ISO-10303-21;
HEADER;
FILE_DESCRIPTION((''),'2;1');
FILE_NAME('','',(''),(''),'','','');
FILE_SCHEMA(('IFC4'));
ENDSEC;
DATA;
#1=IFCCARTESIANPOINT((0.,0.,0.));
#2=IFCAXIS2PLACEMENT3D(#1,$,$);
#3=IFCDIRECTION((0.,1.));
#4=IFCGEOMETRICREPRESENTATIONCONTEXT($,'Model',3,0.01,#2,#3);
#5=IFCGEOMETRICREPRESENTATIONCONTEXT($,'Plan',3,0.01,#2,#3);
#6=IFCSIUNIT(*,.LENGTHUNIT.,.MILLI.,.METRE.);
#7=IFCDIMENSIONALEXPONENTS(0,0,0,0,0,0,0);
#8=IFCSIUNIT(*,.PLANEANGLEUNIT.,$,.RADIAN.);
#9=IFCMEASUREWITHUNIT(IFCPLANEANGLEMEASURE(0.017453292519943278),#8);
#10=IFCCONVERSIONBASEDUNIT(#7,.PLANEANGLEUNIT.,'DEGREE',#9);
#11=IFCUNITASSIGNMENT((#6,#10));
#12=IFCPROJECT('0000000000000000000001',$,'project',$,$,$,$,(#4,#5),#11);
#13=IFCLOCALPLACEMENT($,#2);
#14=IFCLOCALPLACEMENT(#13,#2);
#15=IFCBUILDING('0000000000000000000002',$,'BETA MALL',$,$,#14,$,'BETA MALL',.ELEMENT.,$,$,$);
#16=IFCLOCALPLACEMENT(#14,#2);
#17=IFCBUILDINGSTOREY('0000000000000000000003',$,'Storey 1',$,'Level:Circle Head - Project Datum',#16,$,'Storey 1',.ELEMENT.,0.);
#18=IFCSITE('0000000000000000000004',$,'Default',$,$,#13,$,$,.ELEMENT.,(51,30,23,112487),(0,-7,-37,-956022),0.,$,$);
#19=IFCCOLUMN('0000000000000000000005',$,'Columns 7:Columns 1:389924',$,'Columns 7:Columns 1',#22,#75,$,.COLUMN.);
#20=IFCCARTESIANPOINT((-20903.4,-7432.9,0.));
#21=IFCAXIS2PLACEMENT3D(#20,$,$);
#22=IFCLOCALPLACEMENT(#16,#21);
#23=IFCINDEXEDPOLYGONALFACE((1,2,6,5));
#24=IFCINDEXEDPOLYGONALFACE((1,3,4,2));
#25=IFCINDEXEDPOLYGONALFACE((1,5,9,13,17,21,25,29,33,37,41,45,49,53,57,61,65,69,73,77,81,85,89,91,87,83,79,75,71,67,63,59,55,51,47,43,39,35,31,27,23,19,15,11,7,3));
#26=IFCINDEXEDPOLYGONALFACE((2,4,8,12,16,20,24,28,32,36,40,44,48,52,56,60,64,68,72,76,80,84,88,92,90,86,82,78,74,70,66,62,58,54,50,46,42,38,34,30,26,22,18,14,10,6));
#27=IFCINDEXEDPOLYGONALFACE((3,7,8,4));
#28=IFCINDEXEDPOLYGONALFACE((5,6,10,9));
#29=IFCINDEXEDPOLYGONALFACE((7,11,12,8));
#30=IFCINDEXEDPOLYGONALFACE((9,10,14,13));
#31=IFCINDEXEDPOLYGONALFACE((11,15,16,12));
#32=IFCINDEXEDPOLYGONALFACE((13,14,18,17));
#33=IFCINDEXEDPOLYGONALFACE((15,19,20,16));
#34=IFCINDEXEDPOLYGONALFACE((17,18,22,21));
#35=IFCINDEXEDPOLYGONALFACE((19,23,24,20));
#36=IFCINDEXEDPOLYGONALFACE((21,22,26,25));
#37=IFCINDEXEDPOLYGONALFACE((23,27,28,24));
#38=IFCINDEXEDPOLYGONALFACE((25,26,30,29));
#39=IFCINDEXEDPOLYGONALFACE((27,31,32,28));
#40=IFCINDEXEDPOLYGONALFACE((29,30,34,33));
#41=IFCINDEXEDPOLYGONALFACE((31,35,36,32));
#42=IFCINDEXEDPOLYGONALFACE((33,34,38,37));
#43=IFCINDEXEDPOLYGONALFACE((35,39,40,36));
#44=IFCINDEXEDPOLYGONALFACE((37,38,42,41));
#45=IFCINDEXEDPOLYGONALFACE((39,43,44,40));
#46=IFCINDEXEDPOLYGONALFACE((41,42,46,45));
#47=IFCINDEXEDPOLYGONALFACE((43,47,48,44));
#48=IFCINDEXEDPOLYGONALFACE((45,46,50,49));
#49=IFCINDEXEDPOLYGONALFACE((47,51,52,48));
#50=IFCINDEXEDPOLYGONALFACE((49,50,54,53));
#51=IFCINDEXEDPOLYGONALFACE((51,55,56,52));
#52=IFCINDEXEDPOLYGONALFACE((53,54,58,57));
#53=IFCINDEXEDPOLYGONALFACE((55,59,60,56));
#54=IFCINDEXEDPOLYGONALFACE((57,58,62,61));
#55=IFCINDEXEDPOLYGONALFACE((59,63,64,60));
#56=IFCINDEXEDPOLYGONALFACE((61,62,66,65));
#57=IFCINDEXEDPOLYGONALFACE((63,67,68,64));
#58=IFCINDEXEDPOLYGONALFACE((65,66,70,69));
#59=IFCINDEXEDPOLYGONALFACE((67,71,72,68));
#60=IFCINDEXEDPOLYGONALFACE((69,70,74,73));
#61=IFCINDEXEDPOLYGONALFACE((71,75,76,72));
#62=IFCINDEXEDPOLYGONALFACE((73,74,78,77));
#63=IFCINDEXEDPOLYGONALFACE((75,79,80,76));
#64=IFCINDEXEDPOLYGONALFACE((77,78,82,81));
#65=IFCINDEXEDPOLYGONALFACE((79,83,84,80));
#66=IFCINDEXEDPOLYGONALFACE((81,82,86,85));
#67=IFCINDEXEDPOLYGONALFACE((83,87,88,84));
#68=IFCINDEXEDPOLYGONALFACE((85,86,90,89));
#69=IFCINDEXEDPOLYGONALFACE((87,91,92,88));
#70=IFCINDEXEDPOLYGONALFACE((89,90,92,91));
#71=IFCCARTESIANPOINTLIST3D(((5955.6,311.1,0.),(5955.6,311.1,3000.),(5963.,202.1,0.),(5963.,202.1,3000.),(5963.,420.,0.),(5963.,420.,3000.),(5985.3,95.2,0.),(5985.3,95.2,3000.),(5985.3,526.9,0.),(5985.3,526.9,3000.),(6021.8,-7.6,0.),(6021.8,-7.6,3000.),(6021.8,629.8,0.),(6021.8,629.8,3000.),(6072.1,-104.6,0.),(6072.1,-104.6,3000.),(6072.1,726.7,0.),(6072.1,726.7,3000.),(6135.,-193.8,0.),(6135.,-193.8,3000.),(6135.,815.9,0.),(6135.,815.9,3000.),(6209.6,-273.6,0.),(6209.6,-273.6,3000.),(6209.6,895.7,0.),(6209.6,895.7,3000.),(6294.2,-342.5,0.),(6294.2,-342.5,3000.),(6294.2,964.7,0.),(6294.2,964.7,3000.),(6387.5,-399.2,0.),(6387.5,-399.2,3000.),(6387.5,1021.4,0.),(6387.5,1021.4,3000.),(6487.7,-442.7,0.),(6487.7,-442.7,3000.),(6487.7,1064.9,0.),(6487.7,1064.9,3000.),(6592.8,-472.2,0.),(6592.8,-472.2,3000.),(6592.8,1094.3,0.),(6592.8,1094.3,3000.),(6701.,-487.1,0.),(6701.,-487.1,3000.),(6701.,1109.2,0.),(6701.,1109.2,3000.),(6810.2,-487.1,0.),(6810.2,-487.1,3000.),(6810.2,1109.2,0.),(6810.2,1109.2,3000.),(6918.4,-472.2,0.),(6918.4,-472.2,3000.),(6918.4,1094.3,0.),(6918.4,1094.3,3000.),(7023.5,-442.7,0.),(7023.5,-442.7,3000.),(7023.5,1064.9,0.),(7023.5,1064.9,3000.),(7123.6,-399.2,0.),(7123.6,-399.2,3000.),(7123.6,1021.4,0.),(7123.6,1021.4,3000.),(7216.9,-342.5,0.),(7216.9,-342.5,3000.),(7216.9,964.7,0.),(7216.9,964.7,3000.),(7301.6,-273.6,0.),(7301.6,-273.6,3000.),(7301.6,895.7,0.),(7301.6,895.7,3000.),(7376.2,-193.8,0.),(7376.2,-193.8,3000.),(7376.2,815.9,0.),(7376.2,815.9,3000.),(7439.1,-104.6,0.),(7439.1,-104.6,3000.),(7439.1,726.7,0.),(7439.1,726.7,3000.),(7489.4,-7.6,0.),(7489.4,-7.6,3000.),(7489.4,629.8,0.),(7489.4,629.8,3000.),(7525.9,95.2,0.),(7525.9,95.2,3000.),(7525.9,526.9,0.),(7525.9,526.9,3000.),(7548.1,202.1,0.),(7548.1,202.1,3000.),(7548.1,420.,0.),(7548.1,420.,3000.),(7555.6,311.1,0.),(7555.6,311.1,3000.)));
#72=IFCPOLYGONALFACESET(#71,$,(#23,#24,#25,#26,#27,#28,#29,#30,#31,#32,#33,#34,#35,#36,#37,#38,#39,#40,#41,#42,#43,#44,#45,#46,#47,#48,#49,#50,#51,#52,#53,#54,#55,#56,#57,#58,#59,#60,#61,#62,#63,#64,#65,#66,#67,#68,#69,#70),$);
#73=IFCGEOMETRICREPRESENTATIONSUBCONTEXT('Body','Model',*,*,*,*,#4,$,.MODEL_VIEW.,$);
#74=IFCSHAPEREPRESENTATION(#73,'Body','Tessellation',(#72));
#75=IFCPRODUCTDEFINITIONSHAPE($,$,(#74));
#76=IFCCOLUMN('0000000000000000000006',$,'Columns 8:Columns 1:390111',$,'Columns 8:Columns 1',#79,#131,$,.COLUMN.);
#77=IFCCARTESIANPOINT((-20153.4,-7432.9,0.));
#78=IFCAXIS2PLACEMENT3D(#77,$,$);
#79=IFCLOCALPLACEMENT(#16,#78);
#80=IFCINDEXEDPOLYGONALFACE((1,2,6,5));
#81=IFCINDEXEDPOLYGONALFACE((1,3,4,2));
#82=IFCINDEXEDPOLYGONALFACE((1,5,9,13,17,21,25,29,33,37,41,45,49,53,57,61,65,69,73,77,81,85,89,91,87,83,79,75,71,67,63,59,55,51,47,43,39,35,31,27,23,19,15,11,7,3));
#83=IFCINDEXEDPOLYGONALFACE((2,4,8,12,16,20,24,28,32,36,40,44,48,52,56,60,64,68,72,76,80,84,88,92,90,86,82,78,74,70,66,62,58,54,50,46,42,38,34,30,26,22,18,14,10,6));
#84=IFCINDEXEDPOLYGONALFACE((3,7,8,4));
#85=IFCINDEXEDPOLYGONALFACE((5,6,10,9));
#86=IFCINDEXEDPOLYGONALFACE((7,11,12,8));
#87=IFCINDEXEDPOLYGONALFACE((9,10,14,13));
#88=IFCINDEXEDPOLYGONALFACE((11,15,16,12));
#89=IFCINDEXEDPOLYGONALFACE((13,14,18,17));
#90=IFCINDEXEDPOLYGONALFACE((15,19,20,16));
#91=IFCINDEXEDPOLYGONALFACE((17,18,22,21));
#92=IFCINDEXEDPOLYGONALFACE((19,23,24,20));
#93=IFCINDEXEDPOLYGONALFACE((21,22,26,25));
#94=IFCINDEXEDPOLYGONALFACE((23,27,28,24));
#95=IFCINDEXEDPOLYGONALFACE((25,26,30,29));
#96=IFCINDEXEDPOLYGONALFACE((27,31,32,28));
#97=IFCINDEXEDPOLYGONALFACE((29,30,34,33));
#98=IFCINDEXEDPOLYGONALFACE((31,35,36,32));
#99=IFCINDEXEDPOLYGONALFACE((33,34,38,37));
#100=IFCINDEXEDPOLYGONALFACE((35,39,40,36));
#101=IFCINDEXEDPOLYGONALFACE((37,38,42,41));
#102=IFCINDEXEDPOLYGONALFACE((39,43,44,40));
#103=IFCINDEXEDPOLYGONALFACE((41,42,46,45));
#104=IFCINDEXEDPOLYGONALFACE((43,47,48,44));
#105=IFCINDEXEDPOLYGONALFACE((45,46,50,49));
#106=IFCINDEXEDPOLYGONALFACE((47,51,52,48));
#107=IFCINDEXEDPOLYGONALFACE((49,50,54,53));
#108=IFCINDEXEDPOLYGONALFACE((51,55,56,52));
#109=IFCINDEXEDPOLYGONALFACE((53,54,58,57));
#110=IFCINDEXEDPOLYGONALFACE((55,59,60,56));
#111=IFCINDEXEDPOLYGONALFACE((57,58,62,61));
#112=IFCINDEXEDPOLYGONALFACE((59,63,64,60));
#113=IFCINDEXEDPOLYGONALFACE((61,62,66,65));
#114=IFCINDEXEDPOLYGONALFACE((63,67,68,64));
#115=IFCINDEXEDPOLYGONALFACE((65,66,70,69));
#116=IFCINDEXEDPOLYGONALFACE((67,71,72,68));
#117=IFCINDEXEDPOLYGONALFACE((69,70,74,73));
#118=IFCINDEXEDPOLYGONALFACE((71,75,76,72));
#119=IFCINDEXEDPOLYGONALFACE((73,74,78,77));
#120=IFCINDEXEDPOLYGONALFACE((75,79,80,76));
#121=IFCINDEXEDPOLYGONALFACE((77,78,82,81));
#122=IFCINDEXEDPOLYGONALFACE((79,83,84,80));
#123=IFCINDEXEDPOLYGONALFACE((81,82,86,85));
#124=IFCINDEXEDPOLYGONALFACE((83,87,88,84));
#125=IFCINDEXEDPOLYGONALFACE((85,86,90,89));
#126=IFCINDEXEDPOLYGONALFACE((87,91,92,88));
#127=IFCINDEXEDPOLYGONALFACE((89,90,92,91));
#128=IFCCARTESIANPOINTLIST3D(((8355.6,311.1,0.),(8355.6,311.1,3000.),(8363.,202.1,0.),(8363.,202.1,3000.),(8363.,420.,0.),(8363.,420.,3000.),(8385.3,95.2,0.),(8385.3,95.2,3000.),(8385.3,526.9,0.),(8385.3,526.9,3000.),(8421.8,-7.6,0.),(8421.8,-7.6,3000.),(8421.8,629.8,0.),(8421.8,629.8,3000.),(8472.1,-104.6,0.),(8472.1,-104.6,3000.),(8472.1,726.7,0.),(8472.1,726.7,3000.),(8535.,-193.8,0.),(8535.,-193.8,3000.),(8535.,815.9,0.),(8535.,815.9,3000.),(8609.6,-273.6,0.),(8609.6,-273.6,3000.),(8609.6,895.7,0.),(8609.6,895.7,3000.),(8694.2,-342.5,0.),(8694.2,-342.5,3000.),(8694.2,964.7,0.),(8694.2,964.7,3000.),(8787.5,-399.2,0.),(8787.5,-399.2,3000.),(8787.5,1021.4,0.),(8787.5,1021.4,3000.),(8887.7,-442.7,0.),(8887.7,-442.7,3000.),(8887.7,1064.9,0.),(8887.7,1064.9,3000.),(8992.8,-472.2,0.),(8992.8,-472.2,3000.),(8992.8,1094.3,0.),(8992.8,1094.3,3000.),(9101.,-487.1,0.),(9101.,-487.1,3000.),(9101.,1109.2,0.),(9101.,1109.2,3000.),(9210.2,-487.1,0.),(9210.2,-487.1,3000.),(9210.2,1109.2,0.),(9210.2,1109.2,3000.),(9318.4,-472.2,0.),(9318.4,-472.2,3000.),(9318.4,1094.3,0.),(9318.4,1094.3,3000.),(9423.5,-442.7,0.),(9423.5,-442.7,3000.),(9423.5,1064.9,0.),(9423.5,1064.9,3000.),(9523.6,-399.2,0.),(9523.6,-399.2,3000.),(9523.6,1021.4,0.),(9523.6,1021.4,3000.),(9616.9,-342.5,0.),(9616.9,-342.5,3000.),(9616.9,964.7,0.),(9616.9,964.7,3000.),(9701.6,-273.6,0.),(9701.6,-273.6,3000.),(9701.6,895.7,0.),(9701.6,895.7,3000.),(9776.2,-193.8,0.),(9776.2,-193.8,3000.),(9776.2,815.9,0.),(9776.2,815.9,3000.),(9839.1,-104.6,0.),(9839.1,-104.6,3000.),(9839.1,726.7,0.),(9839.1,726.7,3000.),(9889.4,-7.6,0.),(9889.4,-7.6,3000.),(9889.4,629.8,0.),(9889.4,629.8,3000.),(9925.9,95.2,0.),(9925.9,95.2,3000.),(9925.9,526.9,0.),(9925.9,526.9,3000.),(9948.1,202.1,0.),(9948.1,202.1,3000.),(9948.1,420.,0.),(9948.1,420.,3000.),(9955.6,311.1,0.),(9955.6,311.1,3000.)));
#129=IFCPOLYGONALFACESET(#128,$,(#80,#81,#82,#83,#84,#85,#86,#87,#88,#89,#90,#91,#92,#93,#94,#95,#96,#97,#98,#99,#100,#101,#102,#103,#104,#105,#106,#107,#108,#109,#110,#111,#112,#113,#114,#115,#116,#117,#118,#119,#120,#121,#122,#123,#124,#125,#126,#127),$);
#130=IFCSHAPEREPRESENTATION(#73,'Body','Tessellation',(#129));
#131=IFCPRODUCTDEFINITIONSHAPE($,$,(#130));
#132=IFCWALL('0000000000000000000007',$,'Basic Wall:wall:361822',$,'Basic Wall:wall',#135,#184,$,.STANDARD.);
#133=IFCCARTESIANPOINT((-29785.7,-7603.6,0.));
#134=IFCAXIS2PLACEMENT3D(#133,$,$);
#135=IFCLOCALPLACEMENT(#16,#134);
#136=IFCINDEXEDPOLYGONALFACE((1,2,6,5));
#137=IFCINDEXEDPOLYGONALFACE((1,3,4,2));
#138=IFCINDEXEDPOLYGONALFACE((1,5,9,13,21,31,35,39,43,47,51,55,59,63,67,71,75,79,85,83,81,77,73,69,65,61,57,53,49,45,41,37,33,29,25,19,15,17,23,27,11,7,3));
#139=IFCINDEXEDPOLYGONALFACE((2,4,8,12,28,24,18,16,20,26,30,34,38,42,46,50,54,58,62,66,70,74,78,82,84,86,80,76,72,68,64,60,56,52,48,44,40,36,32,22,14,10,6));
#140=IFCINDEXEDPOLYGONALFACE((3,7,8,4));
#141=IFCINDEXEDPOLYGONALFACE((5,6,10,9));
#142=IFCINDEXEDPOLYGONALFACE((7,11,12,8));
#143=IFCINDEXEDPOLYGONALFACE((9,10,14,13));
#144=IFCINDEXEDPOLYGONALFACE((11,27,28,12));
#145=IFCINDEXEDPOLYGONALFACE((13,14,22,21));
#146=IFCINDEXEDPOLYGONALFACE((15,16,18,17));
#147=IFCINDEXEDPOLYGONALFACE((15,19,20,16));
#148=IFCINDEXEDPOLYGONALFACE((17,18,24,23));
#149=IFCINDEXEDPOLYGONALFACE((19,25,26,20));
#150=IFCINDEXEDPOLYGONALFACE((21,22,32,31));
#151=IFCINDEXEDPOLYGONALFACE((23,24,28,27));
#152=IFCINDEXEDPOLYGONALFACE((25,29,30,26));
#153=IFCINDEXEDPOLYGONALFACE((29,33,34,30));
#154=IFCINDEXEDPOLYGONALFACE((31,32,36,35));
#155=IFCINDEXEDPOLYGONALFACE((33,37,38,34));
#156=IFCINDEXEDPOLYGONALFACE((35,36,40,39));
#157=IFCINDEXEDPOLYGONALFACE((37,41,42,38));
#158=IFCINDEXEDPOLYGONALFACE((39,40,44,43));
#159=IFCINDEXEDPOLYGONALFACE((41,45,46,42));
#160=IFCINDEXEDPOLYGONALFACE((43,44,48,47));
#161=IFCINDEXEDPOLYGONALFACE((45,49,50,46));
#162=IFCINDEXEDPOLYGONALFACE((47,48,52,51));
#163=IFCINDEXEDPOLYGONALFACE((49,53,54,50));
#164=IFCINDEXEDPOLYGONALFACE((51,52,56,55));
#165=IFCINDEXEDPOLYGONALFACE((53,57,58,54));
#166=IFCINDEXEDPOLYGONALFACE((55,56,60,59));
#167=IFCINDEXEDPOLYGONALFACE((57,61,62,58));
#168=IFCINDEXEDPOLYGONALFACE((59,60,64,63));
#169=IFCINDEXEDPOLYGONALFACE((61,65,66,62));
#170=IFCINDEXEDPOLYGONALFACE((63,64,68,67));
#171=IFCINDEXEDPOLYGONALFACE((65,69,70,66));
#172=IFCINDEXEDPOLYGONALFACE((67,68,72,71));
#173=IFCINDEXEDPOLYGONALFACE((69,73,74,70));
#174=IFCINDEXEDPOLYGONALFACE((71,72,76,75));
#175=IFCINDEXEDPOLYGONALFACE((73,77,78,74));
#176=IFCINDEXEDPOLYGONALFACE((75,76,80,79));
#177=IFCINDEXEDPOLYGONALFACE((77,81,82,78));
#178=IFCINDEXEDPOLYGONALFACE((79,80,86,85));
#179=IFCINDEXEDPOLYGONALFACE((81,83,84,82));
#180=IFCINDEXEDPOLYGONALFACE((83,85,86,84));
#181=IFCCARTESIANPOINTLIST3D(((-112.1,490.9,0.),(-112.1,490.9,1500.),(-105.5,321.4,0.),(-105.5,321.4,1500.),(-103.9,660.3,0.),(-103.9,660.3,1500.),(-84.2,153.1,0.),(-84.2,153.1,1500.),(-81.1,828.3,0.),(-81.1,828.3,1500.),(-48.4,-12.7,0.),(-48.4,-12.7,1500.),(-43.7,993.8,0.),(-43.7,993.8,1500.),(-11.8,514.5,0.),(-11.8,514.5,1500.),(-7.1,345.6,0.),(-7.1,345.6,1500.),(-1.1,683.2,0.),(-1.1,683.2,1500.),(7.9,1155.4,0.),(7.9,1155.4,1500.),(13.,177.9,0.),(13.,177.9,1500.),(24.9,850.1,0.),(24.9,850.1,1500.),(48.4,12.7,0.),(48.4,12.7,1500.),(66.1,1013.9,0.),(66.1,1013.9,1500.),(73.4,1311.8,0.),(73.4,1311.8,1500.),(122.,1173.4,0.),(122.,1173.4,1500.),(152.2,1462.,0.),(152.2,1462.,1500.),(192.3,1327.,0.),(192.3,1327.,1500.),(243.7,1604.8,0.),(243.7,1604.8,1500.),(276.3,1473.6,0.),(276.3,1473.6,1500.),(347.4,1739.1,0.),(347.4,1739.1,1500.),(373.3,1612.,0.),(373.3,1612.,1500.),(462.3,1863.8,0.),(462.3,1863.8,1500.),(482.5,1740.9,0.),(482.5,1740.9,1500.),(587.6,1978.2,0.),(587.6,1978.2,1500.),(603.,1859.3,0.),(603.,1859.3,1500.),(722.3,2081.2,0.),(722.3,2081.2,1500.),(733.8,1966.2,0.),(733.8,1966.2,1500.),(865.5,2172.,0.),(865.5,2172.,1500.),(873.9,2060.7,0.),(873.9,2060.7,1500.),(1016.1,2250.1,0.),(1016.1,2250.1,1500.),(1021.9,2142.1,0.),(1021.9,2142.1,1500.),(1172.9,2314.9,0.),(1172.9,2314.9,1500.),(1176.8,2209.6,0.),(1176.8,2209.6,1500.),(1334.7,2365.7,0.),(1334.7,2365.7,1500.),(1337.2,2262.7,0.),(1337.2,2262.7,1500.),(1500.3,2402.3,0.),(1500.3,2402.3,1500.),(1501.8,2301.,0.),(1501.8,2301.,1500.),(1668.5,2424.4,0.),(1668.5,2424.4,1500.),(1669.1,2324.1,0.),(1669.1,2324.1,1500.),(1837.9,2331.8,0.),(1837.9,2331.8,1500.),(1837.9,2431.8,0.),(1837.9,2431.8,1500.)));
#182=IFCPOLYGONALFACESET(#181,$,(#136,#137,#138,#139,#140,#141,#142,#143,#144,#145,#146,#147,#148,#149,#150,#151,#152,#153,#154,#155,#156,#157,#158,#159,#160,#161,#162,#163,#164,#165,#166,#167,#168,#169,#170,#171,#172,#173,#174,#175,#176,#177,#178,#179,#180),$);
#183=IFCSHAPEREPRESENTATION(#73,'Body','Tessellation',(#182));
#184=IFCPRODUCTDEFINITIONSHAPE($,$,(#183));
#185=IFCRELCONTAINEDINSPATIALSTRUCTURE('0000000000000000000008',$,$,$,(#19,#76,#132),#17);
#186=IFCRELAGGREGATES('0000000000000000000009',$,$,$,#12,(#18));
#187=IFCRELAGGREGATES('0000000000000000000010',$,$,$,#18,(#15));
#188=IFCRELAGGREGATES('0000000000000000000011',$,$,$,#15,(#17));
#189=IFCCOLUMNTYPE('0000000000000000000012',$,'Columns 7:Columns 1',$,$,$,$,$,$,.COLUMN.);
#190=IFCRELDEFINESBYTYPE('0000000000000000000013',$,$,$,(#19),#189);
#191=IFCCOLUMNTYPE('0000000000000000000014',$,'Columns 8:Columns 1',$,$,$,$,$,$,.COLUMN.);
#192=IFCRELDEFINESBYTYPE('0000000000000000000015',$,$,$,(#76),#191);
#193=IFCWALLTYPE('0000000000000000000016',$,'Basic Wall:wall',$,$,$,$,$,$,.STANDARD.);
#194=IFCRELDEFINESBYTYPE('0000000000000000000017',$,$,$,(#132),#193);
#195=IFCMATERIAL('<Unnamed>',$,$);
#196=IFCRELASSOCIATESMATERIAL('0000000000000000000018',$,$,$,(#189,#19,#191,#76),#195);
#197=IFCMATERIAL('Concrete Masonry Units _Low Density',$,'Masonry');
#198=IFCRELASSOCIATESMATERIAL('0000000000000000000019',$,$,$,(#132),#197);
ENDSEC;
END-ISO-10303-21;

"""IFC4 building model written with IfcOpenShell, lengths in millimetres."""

from ifc_helpers import new_model, entity, si_unit, converted_unit, direction, frame, origin, place, context, subcontext, project, spatial, line, arc, indexed_curve, outline, extrude, source, transform, mapped, material, type_object, type_shapes, element, save


model = new_model("IFC4")

# Units and contexts
model_context = context("Model", 3, precision=0.01, world=origin(), true_north=direction((0.0, 1.0)))
plan_context = context("Plan", 3, precision=0.01, world=origin(), true_north=direction((0.0, 1.0)))
body_context = subcontext(model_context, "Body", "Model", "MODEL_VIEW")
ifc_project = project(units=[si_unit("LENGTHUNIT", "METRE", prefix="MILLI"), converted_unit("PLANEANGLEUNIT", "DEGREE", entity("IfcPlaneAngleMeasure", 0.017453292519943278), si_unit("PLANEANGLEUNIT", "RADIAN"), dimensions=[0, 0, 0, 0, 0, 0, 0])], contexts=[model_context, plan_context])

# Site, building, storey
site_placement = place(None, origin())
site = spatial("IfcSite", under=ifc_project, at=site_placement, Name="Default", CompositionType="ELEMENT", RefLatitude=(51, 30, 23, 112487), RefLongitude=(0, -7, -37, -956022), RefElevation=0.0)
building_placement = place(site_placement, origin())
building = spatial("IfcBuilding", under=site, at=building_placement, Name="BETA MALL", LongName="BETA MALL", CompositionType="ELEMENT")
storey_placement = place(building_placement, origin())
storey = spatial("IfcBuildingStorey", under=building, at=storey_placement, Name="Storey 1", ObjectType="Level:Circle Head - Project Datum", LongName="Storey 1", CompositionType="ELEMENT", Elevation=0.0)

# Columns
ifc_material_1 = material(Name="<Unnamed>")
column_type_1 = type_object("IfcColumnType", Name="Columns 7:Columns 1", PredefinedType="COLUMN", material=ifc_material_1)
shared_shape_1 = source(origin(), body_context, "Body", "SweptSolid", [
    extrude(outline(indexed_curve([(-800.0, 0.0), (0.0, -800.0), (800.0, 0.0), (0.0, 800.0)], segments=[arc(1, 2, 3), arc(3, 4, 1)], self_intersect=False)), frame((6755.6, 311.1, 0.0)), (0.0, 0.0, 1.0), 3000.0),
])
type_shapes(column_type_1, [shared_shape_1])
column_1_placement = place(storey_placement, frame((-20903.4, -7432.9, 0.0)))
element("IfcColumn", 1, at=column_1_placement, inside=storey, type_object=column_type_1, material=ifc_material_1, Name="Columns 7:Columns 1:389924", ObjectType="Columns 7:Columns 1", PredefinedType="COLUMN", context=body_context, shape_type="MappedRepresentation", body=[
    mapped(shared_shape_1, transform((0.0, 0.0, 0.0), scale=1.0)),
])
column_type_2 = type_object("IfcColumnType", Name="Columns 8:Columns 1", PredefinedType="COLUMN", material=ifc_material_1)
shared_shape_2 = source(origin(), body_context, "Body", "SweptSolid", [
    extrude(outline(indexed_curve([(-800.0, 0.0), (0.0, -800.0), (800.0, 0.0), (0.0, 800.0)], segments=[arc(1, 2, 3), arc(3, 4, 1)], self_intersect=False)), frame((9155.6, 311.1, 0.0)), (0.0, 0.0, 1.0), 3000.0),
])
type_shapes(column_type_2, [shared_shape_2])
column_2_placement = place(storey_placement, frame((-20153.4, -7432.9, 0.0)))
element("IfcColumn", 2, at=column_2_placement, inside=storey, type_object=column_type_2, material=ifc_material_1, Name="Columns 8:Columns 1:390111", ObjectType="Columns 8:Columns 1", PredefinedType="COLUMN", context=body_context, shape_type="MappedRepresentation", body=[
    mapped(shared_shape_2, transform((0.0, 0.0, 0.0), scale=1.0)),
])

# Wall
ifc_material_2 = material(Name="Concrete Masonry Units _Low Density", Category="Masonry")
wall_type = type_object("IfcWallType", Name="Basic Wall:wall", PredefinedType="STANDARD")
wall_1_placement = place(storey_placement, frame((-29785.7, -7603.6, 0.0)))
element("IfcWall", 3, at=wall_1_placement, inside=storey, type_object=wall_type, material=ifc_material_2, Name="Basic Wall:wall:361822", ObjectType="Basic Wall:wall", PredefinedType="STANDARD", context=body_context, shape_type="SweptSolid", body=[
    extrude(outline(indexed_curve([(1837.9, 2431.8), (294.1, 1673.1), (-48.4, -12.7), (48.4, 12.7), (373.3, 1612.0), (1837.9, 2331.8)], segments=[arc(1, 2, 3), line(3, 4), arc(4, 5, 6), line(6, 1)], self_intersect=False)), origin(), (0.0, 0.0, 1.0), 1500.0),
])

save(model, "model.ifc")
